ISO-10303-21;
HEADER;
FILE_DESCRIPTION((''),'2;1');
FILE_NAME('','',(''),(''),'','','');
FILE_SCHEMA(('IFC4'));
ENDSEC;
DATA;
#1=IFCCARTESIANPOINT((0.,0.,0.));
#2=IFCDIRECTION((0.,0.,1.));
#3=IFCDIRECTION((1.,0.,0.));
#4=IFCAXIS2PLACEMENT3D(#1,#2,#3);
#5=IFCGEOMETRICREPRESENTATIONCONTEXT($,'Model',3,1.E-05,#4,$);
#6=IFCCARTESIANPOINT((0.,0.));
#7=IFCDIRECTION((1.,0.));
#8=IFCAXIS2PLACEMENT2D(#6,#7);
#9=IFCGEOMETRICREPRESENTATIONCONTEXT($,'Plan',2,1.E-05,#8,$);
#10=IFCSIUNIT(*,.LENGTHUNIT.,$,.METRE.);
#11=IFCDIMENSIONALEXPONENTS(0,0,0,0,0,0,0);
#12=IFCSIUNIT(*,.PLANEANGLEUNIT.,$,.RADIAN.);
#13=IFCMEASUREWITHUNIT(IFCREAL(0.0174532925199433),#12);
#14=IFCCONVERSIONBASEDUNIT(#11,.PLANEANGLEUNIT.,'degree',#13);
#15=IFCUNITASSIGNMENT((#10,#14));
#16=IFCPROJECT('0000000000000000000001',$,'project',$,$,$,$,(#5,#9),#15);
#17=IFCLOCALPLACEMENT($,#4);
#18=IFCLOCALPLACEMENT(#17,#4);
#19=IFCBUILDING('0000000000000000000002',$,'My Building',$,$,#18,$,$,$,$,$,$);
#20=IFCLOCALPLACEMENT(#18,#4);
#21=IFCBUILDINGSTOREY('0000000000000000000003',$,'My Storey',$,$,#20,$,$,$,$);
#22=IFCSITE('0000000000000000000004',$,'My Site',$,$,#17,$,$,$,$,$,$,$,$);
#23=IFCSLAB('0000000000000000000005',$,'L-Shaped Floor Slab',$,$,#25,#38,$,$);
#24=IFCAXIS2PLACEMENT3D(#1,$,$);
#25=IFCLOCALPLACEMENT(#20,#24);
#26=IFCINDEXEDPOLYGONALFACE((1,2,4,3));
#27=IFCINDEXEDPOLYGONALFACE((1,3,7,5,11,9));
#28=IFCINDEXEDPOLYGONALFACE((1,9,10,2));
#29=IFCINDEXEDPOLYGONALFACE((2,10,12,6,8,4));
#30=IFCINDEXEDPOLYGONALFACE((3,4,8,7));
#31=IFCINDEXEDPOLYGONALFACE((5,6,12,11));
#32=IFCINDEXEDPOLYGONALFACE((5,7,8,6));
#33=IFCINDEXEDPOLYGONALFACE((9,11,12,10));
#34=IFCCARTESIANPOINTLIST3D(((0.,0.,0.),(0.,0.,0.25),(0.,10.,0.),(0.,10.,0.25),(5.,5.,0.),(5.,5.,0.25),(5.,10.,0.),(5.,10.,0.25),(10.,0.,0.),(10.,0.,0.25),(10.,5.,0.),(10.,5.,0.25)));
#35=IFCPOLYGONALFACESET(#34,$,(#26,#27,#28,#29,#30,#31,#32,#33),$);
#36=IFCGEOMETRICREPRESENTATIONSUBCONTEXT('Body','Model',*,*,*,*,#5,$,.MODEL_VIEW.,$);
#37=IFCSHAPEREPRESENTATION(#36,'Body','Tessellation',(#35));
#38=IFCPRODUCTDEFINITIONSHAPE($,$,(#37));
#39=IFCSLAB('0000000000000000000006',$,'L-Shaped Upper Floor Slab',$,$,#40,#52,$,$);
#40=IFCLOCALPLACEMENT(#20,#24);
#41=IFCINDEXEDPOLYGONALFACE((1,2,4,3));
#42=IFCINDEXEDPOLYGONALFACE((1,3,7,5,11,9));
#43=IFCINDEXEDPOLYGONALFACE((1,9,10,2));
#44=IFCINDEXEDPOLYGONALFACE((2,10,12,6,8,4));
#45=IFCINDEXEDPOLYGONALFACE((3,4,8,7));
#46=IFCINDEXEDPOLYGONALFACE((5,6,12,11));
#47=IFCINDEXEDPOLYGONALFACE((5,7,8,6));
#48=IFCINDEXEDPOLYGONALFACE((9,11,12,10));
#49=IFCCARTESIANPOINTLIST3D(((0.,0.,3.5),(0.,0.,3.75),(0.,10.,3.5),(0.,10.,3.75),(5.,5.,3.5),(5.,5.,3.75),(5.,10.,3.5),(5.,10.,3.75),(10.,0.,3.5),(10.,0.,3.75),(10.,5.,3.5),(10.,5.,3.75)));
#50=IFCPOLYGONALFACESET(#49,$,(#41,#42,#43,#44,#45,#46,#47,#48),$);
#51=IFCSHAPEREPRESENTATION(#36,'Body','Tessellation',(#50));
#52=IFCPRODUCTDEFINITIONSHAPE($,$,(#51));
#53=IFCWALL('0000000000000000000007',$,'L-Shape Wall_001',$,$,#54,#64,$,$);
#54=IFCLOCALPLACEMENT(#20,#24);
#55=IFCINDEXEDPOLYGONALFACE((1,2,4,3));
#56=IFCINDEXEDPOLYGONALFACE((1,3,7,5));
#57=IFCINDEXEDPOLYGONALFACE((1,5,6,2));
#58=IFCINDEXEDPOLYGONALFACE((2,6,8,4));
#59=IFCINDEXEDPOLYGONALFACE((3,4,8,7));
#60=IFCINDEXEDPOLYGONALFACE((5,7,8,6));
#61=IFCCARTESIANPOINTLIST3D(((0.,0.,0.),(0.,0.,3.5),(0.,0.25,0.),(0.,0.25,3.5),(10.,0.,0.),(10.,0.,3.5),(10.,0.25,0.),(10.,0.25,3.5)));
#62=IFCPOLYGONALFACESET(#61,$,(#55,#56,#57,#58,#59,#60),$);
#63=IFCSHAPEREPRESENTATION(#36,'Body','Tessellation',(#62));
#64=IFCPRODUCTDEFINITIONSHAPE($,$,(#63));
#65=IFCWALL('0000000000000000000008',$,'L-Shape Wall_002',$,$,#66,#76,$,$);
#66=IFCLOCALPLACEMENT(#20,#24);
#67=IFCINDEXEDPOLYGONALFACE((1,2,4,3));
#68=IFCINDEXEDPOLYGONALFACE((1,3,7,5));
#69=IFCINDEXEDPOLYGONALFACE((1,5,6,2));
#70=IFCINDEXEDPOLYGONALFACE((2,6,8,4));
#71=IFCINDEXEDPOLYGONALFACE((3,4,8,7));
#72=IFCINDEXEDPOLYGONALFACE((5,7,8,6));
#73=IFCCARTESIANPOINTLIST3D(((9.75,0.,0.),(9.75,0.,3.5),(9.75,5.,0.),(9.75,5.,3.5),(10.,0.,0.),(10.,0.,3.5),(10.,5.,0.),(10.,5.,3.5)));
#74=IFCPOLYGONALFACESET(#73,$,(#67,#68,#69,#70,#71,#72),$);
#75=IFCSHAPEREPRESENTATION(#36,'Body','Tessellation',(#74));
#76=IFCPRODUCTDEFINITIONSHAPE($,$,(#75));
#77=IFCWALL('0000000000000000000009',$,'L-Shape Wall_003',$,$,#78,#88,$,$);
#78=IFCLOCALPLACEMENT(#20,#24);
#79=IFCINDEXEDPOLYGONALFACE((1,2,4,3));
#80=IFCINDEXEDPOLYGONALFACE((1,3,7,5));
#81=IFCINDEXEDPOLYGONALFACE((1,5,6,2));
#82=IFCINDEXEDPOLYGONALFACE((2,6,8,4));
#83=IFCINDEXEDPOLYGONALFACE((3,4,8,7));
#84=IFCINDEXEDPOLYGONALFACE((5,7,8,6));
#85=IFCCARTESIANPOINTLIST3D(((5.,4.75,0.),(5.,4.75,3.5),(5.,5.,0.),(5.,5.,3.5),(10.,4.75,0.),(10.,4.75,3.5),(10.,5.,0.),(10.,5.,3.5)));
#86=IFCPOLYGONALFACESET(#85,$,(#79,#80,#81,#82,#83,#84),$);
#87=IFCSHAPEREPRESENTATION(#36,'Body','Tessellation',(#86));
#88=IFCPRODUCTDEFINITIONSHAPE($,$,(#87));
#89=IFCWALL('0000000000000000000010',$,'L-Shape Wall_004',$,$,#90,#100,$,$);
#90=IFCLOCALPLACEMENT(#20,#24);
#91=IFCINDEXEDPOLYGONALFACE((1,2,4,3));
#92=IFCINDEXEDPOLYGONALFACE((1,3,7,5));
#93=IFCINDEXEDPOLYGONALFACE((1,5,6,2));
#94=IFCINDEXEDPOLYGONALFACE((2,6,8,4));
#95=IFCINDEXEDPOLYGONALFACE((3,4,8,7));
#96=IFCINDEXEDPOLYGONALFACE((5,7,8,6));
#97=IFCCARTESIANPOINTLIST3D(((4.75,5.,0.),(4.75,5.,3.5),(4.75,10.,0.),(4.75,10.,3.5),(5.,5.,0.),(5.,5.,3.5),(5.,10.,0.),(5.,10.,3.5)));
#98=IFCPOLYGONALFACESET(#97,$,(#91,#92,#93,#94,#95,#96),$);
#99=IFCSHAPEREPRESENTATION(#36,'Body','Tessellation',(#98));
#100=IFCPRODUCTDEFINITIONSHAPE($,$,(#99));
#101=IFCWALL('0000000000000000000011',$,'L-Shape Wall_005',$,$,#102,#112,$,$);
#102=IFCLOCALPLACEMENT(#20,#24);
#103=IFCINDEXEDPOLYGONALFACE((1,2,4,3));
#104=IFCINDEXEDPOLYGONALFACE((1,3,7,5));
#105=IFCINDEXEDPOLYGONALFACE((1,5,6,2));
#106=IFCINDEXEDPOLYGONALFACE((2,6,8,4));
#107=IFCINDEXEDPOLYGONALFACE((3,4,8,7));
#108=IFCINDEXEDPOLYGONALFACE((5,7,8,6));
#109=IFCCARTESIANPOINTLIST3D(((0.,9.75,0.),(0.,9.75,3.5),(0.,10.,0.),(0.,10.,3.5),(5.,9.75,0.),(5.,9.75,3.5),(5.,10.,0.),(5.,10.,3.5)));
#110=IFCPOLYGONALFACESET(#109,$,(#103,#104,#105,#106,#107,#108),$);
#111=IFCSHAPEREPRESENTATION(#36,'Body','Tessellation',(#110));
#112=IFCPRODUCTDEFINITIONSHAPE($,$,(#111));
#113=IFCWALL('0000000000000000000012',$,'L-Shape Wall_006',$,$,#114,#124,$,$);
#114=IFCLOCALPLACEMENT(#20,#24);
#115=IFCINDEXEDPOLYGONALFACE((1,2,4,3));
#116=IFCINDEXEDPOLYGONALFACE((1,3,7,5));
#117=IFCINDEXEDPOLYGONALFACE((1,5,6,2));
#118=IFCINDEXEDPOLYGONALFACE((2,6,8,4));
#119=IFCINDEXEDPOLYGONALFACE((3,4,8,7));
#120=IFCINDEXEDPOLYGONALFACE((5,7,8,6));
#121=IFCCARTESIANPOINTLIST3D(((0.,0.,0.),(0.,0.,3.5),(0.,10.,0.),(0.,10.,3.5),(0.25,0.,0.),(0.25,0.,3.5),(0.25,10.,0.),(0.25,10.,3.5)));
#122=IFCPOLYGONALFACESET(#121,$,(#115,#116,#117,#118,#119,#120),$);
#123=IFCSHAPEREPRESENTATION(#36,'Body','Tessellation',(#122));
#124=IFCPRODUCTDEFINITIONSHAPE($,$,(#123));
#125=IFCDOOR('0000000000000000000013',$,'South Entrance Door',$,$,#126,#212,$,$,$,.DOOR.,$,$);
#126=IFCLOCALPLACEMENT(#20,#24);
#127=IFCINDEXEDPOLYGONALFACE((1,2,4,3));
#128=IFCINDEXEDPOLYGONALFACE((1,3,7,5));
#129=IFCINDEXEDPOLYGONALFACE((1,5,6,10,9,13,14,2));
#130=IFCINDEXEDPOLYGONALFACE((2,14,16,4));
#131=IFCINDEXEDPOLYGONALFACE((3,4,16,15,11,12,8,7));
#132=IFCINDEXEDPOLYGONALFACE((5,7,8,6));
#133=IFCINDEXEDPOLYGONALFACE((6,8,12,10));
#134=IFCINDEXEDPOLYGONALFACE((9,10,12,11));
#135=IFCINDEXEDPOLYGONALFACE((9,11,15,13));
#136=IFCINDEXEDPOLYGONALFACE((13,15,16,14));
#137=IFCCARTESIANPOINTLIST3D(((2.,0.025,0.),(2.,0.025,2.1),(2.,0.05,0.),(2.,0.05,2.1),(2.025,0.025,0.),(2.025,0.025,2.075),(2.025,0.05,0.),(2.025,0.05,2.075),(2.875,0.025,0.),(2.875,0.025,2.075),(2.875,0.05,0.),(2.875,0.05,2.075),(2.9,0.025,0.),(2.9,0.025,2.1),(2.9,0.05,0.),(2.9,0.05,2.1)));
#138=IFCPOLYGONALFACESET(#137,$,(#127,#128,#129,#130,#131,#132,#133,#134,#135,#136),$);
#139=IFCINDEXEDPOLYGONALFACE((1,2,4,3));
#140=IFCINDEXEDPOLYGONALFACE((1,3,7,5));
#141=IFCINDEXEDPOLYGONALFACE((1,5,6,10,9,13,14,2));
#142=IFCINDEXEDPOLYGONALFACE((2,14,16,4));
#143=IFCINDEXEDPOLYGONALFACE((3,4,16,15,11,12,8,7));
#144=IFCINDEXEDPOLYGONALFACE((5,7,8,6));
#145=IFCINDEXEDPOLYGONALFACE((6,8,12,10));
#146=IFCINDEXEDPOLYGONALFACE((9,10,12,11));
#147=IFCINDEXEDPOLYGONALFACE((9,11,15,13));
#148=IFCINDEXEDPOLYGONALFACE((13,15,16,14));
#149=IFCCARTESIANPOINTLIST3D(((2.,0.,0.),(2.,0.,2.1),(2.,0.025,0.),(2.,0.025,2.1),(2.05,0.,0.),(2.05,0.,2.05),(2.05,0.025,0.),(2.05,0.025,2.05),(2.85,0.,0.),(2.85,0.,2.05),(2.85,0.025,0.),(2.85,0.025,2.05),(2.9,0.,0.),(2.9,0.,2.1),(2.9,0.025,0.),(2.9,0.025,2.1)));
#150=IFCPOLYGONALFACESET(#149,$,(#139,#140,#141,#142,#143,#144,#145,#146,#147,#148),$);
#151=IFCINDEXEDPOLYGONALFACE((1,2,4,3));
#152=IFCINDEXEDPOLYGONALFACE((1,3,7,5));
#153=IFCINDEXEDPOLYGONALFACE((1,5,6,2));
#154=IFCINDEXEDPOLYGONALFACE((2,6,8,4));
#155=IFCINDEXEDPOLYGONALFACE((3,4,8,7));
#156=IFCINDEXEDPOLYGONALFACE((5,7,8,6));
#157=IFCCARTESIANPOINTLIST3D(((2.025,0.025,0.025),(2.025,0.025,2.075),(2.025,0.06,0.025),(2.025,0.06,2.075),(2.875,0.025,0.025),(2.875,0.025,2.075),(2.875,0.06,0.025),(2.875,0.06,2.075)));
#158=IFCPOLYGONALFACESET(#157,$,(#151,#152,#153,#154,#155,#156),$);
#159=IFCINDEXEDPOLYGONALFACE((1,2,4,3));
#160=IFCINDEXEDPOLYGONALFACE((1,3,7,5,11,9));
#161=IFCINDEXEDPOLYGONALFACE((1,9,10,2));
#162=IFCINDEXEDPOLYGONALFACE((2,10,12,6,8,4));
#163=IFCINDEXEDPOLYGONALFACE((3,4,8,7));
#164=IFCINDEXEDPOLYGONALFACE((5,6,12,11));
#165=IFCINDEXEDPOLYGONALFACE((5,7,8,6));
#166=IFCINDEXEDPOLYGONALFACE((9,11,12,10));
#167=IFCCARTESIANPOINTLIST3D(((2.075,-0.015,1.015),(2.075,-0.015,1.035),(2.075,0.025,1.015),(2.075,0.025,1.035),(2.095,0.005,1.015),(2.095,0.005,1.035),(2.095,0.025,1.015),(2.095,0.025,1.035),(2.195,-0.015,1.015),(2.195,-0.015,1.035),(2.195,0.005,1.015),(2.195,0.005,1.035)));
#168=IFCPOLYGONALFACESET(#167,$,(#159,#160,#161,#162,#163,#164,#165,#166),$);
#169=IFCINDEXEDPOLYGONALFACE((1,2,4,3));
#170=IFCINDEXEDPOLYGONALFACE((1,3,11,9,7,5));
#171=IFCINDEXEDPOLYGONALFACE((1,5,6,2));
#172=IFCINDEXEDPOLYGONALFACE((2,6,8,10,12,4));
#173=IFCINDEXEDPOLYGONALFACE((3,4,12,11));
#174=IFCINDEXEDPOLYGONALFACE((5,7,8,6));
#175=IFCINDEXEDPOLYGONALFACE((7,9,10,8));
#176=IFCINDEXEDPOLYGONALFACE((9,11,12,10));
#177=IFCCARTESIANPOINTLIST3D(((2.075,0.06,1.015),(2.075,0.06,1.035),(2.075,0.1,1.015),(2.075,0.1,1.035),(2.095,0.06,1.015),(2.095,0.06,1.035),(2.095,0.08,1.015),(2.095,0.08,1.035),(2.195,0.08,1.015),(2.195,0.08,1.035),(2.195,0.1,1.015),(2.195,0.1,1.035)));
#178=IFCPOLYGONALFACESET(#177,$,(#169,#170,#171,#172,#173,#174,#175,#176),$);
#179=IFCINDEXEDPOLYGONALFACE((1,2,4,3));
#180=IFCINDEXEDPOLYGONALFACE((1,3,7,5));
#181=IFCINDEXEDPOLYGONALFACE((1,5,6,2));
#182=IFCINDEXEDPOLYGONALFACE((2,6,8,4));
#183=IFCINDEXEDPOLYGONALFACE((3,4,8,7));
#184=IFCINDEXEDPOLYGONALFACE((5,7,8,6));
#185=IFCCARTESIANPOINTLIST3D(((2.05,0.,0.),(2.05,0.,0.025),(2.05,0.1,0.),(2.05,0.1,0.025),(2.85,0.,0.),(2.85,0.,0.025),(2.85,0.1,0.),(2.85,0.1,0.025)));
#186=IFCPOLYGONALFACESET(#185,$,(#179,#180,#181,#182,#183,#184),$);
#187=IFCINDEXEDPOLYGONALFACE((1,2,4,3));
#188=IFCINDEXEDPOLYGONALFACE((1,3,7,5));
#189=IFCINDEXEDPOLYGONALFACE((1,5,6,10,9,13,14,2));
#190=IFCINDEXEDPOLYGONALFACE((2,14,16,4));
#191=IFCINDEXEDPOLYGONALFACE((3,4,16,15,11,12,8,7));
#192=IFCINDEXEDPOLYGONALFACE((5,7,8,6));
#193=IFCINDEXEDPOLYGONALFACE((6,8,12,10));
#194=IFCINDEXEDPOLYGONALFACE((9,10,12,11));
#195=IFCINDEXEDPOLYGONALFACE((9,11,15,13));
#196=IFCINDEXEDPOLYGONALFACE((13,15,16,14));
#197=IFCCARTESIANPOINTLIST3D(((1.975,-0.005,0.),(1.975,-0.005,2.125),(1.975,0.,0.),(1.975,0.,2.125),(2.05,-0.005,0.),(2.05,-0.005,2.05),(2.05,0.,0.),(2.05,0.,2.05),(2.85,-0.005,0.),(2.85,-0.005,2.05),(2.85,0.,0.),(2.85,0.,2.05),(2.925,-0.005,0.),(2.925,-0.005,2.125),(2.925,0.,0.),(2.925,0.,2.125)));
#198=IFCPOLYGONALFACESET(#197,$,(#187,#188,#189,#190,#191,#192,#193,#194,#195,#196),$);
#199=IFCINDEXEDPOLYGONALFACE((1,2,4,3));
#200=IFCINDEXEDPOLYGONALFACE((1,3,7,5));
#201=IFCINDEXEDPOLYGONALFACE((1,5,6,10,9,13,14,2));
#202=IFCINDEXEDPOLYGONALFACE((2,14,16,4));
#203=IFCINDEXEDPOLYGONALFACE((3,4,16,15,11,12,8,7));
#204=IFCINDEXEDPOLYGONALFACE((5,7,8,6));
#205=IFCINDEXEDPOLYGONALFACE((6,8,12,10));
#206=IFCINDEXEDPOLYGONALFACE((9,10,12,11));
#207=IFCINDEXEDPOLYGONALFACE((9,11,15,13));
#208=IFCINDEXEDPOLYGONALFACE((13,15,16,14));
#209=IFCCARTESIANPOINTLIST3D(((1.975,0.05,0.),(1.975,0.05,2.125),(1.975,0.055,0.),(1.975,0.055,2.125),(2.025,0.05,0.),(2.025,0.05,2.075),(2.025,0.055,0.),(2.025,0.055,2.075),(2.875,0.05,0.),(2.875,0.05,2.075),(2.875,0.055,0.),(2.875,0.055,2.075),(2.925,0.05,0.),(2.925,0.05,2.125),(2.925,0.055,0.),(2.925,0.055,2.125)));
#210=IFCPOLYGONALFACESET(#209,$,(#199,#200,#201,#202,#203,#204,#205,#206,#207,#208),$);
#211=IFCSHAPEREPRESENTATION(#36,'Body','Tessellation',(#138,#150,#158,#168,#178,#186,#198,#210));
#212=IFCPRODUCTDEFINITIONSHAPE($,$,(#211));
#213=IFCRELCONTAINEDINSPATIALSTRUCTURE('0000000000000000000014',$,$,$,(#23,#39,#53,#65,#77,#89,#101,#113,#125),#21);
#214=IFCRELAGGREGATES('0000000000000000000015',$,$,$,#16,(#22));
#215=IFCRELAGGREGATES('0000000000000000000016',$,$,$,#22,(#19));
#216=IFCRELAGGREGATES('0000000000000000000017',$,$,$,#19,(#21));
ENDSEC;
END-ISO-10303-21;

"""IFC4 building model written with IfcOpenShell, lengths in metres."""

from ifc_helpers import new_model, entity, si_unit, converted_unit, frame, origin_with_axes, origin_2d_with_axis, place, context, subcontext, project, spatial, line, indexed_curve, outline, extrude, element, save


model = new_model("IFC4")

# Units and contexts
model_context = context("Model", 3, precision=1e-05, world=origin_with_axes())
plan_context = context("Plan", 2, precision=1e-05, world=origin_2d_with_axis())
body_context = subcontext(model_context, "Body", "Model", "MODEL_VIEW")
ifc_project = project(units=[si_unit("LENGTHUNIT", "METRE"), converted_unit("PLANEANGLEUNIT", "degree", entity("IfcReal", 0.0174532925199433), si_unit("PLANEANGLEUNIT", "RADIAN"), dimensions=[0, 0, 0, 0, 0, 0, 0])], contexts=[model_context, plan_context])

# Site, building, storey
site_placement = place(None, origin_with_axes())
site = spatial("IfcSite", under=ifc_project, at=site_placement, Name="My Site")
building_placement = place(site_placement, origin_with_axes())
building = spatial("IfcBuilding", under=site, at=building_placement, Name="My Building")
storey_placement = place(building_placement, origin_with_axes())
storey = spatial("IfcBuildingStorey", under=building, at=storey_placement, Name="My Storey")

# Slabs
for number, where, z_axis, x_axis, name in (
    (1, (0.0, 0.0, 0.0), (0.0, 0.0, 1.0), (1.0, 0.0, 0.0), "L-Shaped Floor Slab"),
    (2, (0.0, 0.0, 3.5), (0.0, 0.0, 1.0), (1.0, 0.0, 0.0), "L-Shaped Upper Floor Slab"),
):
    element("IfcSlab", number, at=place(storey_placement, frame(where, z_axis=z_axis, x_axis=x_axis)), inside=storey, Name=name, context=body_context, shape_type="SweptSolid", body=[
        extrude(outline(indexed_curve([(0.0, 0.0), (10.0, 0.0), (10.0, 5.0), (5.0, 5.0), (5.0, 10.0), (0.0, 10.0)])), None, (0.0, 0.0, 1.0), 0.25),
    ])

# Walls
wall_1_placement = place(storey_placement, origin_with_axes())
element("IfcWall", 3, at=wall_1_placement, inside=storey, Name="L-Shape Wall_001", context=body_context, shape_type="SweptSolid", body=[
    extrude(outline(indexed_curve([(0.0, 0.0), (0.0, 0.25), (10.0, 0.25), (10.0, 0.0), (0.0, 0.0)], self_intersect=False)), origin_with_axes(), (0.0, 0.0, 1.0), 3.5),
])
for number, where, z_axis, x_axis, name in (
    (4, (10.0, 0.0, 0.0), (0.0, 0.0, 1.0), (0.0, 1.0, 0.0), "L-Shape Wall_002"),
    (5, (10.0, 5.0, 0.0), (0.0, 0.0, 1.0), (-1.0, 0.0, 0.0), "L-Shape Wall_003"),
    (6, (5.0, 5.0, 0.0), (0.0, 0.0, 1.0), (0.0, 1.0, 0.0), "L-Shape Wall_004"),
    (7, (5.0, 10.0, 0.0), (0.0, 0.0, 1.0), (-1.0, 0.0, 0.0), "L-Shape Wall_005"),
):
    element("IfcWall", number, at=place(storey_placement, frame(where, z_axis=z_axis, x_axis=x_axis)), inside=storey, Name=name, context=body_context, shape_type="SweptSolid", body=[
        extrude(outline(indexed_curve([(0.0, 0.0), (0.0, 0.25), (5.0, 0.25), (5.0, 0.0), (0.0, 0.0)], self_intersect=False)), origin_with_axes(), (0.0, 0.0, 1.0), 3.5),
    ])
wall_2_placement = place(storey_placement, frame((0.0, 10.0, 0.0), z_axis=(0.0, 0.0, 1.0), x_axis=(0.0, -1.0, 0.0)))
element("IfcWall", 8, at=wall_2_placement, inside=storey, Name="L-Shape Wall_006", context=body_context, shape_type="SweptSolid", body=[
    extrude(outline(indexed_curve([(0.0, 0.0), (0.0, 0.25), (10.0, 0.25), (10.0, 0.0), (0.0, 0.0)], self_intersect=False)), origin_with_axes(), (0.0, 0.0, 1.0), 3.5),
])

# Door
door_placement = place(storey_placement, frame((2.0, 0.0, 0.0), z_axis=(0.0, 0.0, 1.0), x_axis=(1.0, 0.0, 0.0)))
element("IfcDoor", 9, at=door_placement, inside=storey, Name="South Entrance Door", PredefinedType="DOOR", context=body_context, shape_type="SweptSolid", body=[
    extrude(outline(indexed_curve([(0.0, 0.0), (0.0, 2.1), (0.9, 2.1), (0.9, 0.0), (0.875, 0.0), (0.875, 2.075), (0.025, 2.075), (0.025, 0.0)], segments=[line(1, 2, 3, 4, 5, 6, 7, 8, 1)])), frame((0.0, 0.025, 0.0), z_axis=(0.0, -1.0, 0.0), x_axis=(1.0, 0.0, 0.0)), (0.0, 0.0, -1.0), 0.025),
    extrude(outline(indexed_curve([(0.0, 0.0), (0.0, 2.1), (0.9, 2.1), (0.9, 0.0), (0.85, 0.0), (0.85, 2.05), (0.05, 2.05), (0.05, 0.0)], segments=[line(1, 2, 3, 4, 5, 6, 7, 8, 1)])), frame((0.0, 0.0, 0.0), z_axis=(0.0, -1.0, 0.0), x_axis=(1.0, 0.0, 0.0)), (0.0, 0.0, -1.0), 0.025),
    extrude(outline(indexed_curve([(0.0, 0.0), (0.85, 0.0), (0.85, 0.035), (0.0, 0.035)], segments=[line(1, 2, 3, 4, 1)])), frame((0.025, 0.025, 0.025), z_axis=(0.0, 0.0, 1.0), x_axis=(1.0, 0.0, 0.0)), (0.0, 0.0, 1.0), 2.05),
    extrude(outline(indexed_curve([(0.0, 0.0), (0.0, -0.04), (0.12, -0.04), (0.12, -0.02), (0.02, -0.02), (0.02, 0.0)], segments=[line(1, 2, 3, 4, 5, 6, 1)])), frame((0.075, 0.025, 1.015), z_axis=(0.0, 0.0, 1.0), x_axis=(1.0, 0.0, 0.0)), (0.0, 0.0, 1.0), 0.02),
    extrude(outline(indexed_curve([(0.0, 0.0), (0.0, 0.04), (0.12, 0.04), (0.12, 0.02), (0.02, 0.02), (0.02, 0.0)], segments=[line(1, 2, 3, 4, 5, 6, 1)])), frame((0.075, 0.06, 1.015), z_axis=(0.0, 0.0, 1.0), x_axis=(1.0, 0.0, 0.0)), (0.0, 0.0, 1.0), 0.02),
    extrude(outline(indexed_curve([(0.0, 0.0), (0.8, 0.0), (0.8, 0.1), (0.0, 0.1)], segments=[line(1, 2, 3, 4, 1)])), frame((0.05, 0.0, 0.0), z_axis=(0.0, 0.0, 1.0), x_axis=(1.0, 0.0, 0.0)), (0.0, 0.0, 1.0), 0.025),
    extrude(outline(indexed_curve([(0.0, 0.0), (0.0, 2.125), (0.95, 2.125), (0.95, 0.0), (0.875, 0.0), (0.875, 2.05), (0.075, 2.05), (0.075, 0.0)], segments=[line(1, 2, 3, 4, 5, 6, 7, 8, 1)])), frame((-0.025, -0.005, 0.0), z_axis=(0.0, -1.0, 0.0), x_axis=(1.0, 0.0, 0.0)), (0.0, 0.0, -1.0), 0.005),
    extrude(outline(indexed_curve([(0.0, 0.0), (0.0, 2.125), (0.95, 2.125), (0.95, 0.0), (0.9, 0.0), (0.9, 2.075), (0.05, 2.075), (0.05, 0.0)], segments=[line(1, 2, 3, 4, 5, 6, 7, 8, 1)])), frame((-0.025, 0.05, 0.0), z_axis=(0.0, -1.0, 0.0), x_axis=(1.0, 0.0, 0.0)), (0.0, 0.0, -1.0), 0.005),
])

save(model, "model.ifc")
